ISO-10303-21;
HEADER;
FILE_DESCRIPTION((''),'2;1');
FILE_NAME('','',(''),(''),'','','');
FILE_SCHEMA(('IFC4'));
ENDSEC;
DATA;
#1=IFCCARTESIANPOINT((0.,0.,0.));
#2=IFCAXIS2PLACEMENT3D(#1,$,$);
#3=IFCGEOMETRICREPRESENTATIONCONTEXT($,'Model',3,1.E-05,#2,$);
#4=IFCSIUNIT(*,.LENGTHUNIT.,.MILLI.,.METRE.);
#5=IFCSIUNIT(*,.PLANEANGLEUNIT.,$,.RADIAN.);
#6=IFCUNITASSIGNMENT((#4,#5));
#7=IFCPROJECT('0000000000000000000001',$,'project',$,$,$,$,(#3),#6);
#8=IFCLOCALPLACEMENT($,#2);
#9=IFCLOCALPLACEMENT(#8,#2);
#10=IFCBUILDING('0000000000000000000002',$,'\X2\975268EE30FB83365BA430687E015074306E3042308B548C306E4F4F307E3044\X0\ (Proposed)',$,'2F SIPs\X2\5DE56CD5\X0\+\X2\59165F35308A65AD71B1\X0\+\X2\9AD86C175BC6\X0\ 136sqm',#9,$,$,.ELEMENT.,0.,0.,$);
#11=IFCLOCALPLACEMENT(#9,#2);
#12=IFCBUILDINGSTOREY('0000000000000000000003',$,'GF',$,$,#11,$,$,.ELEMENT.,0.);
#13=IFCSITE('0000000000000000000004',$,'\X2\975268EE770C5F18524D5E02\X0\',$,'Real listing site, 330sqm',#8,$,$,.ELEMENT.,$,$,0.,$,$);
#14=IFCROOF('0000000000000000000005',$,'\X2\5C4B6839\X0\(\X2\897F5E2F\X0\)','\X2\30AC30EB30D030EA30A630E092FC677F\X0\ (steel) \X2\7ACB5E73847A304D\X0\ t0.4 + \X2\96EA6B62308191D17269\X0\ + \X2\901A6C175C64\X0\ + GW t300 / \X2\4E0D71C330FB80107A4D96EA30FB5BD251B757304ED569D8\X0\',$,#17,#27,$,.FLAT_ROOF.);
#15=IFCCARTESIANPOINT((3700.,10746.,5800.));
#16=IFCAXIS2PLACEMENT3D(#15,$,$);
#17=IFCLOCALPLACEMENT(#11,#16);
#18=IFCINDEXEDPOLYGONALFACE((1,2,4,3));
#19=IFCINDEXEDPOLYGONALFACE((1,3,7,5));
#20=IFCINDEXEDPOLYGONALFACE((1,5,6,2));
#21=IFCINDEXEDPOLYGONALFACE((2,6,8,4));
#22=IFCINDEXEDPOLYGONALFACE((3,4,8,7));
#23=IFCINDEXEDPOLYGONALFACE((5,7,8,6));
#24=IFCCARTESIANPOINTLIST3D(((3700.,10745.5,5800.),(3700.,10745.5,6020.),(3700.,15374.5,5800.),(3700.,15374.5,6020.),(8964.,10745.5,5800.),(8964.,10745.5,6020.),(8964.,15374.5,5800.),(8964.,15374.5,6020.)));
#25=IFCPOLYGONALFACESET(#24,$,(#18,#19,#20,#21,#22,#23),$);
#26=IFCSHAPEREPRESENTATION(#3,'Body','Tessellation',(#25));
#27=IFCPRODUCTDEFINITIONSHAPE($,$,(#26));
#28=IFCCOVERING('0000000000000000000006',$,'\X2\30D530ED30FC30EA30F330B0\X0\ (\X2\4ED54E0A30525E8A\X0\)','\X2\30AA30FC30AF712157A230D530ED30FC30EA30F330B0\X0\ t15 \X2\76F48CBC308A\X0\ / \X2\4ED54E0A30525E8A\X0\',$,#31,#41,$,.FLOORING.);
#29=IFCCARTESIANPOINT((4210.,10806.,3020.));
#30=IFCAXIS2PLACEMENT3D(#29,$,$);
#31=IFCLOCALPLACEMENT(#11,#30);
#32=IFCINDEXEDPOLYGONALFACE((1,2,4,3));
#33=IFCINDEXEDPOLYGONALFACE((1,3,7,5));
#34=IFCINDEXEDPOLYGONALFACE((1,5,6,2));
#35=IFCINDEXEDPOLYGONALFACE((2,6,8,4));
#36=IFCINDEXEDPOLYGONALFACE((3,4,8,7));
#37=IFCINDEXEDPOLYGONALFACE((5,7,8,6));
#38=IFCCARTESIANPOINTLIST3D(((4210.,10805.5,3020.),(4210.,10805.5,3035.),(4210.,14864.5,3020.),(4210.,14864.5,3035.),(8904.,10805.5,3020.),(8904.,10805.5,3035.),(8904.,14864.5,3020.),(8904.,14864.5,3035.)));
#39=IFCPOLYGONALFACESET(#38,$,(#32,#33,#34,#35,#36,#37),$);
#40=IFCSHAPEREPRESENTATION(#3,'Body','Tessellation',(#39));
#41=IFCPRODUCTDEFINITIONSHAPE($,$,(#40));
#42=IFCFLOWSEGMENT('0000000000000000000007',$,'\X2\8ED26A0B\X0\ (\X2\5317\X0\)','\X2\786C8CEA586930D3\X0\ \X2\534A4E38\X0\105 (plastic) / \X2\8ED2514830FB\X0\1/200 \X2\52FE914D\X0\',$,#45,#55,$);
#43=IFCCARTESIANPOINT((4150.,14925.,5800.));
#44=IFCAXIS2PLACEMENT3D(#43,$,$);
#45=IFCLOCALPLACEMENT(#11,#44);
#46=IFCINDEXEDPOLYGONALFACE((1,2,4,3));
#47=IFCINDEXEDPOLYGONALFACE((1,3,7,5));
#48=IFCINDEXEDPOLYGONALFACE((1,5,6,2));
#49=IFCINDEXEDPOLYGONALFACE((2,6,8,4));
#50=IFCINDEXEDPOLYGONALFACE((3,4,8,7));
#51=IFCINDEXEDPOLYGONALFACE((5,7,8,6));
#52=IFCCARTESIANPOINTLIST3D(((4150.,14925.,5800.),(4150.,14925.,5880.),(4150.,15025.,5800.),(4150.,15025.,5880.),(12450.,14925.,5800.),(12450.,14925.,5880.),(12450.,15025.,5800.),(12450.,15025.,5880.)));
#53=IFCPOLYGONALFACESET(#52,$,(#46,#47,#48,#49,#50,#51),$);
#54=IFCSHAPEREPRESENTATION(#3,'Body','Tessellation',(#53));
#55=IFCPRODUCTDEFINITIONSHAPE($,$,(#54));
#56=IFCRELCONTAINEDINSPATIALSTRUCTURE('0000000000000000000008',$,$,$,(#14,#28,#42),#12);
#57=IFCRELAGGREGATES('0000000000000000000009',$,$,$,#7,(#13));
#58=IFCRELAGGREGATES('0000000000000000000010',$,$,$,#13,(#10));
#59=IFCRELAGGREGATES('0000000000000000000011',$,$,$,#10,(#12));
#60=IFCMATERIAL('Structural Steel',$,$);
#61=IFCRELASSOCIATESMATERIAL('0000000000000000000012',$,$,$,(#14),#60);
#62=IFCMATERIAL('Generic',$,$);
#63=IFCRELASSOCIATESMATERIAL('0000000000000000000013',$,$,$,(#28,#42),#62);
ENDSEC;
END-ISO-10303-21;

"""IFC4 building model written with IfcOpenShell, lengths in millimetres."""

from ifc_helpers import new_model, si_unit, frame, frame_2d, origin, place, context, project, spatial, rectangle, extrude, material, element, save


model = new_model("IFC4")

# Units and contexts
model_context = context("Model", 3, precision=1e-05, world=origin())
ifc_project = project(units=[si_unit("LENGTHUNIT", "METRE", prefix="MILLI"), si_unit("PLANEANGLEUNIT", "RADIAN")], contexts=[model_context])

# Site, building, storey
site_placement = place(None, origin())
site = spatial("IfcSite", under=ifc_project, at=site_placement, Name="青森県弘前市", ObjectType="Real listing site, 330sqm", CompositionType="ELEMENT", RefElevation=0.0)
building_placement = place(site_placement, origin())
building = spatial("IfcBuilding", under=site, at=building_placement, Name="青森・茶室と縁側のある和の住まい (Proposed)", ObjectType="2F SIPs工法+外張り断熱+高気密 136sqm", CompositionType="ELEMENT", ElevationOfRefHeight=0.0, ElevationOfTerrain=0.0)
storey_placement = place(building_placement, origin())
storey = spatial("IfcBuildingStorey", under=building, at=storey_placement, Name="GF", CompositionType="ELEMENT", Elevation=0.0)

# Roof
ifc_material_1 = material(Name="Structural Steel")
for number, where, name in (
    (1, (3700.0, 10746.0, 5800.0), "屋根(西帯)"),
):
    element("IfcRoof", number, at=place(storey_placement, frame(where)), inside=storey, material=ifc_material_1, Name=name, Description="ガルバリウム鋼板 (steel) 立平葺き t0.4 + 雪止め金物 + 通気層 + GW t300 / 不燃・耐積雪・寒冷地仕様", PredefinedType="FLAT_ROOF", context=model_context, shape_type="SweptSolid", body=[
        extrude(rectangle(XDim=5264.0, YDim=4629.0, at=frame_2d((2632.0, 2314.0))), frame((3700.0, 10746.0, 5800.0)), (0.0, 0.0, 1.0), 220.0),
    ])

# Covering
ifc_material_2 = material(Name="Generic")
covering_placement = place(storey_placement, frame((4210.0, 10806.0, 3020.0)))
element("IfcCovering", 2, at=covering_placement, inside=storey, material=ifc_material_2, Name="フローリング (仕上げ床)", Description="オーク無垢フローリング t15 直貼り / 仕上げ床", PredefinedType="FLOORING", context=model_context, shape_type="SweptSolid", body=[
    extrude(rectangle(XDim=4694.0, YDim=4059.0, at=frame_2d((2347.0, 2029.0))), frame((4210.0, 10806.0, 3020.0)), (0.0, 0.0, 1.0), 15.0),
])

# Flow segment
flow_segment_placement = place(storey_placement, frame((4150.0, 14925.0, 5800.0)))
element("IfcFlowSegment", 3, at=flow_segment_placement, inside=storey, material=ifc_material_2, Name="軒樋 (北)", Description="硬質塩ビ 半丸105 (plastic) / 軒先・1/200 勾配", context=model_context, shape_type="SweptSolid", body=[
    extrude(rectangle(XDim=8300.0, YDim=100.0, at=frame_2d((4150.0, 50.0))), frame((4150.0, 14925.0, 5800.0)), (0.0, 0.0, 1.0), 80.0),
])

save(model, "model.ifc")
